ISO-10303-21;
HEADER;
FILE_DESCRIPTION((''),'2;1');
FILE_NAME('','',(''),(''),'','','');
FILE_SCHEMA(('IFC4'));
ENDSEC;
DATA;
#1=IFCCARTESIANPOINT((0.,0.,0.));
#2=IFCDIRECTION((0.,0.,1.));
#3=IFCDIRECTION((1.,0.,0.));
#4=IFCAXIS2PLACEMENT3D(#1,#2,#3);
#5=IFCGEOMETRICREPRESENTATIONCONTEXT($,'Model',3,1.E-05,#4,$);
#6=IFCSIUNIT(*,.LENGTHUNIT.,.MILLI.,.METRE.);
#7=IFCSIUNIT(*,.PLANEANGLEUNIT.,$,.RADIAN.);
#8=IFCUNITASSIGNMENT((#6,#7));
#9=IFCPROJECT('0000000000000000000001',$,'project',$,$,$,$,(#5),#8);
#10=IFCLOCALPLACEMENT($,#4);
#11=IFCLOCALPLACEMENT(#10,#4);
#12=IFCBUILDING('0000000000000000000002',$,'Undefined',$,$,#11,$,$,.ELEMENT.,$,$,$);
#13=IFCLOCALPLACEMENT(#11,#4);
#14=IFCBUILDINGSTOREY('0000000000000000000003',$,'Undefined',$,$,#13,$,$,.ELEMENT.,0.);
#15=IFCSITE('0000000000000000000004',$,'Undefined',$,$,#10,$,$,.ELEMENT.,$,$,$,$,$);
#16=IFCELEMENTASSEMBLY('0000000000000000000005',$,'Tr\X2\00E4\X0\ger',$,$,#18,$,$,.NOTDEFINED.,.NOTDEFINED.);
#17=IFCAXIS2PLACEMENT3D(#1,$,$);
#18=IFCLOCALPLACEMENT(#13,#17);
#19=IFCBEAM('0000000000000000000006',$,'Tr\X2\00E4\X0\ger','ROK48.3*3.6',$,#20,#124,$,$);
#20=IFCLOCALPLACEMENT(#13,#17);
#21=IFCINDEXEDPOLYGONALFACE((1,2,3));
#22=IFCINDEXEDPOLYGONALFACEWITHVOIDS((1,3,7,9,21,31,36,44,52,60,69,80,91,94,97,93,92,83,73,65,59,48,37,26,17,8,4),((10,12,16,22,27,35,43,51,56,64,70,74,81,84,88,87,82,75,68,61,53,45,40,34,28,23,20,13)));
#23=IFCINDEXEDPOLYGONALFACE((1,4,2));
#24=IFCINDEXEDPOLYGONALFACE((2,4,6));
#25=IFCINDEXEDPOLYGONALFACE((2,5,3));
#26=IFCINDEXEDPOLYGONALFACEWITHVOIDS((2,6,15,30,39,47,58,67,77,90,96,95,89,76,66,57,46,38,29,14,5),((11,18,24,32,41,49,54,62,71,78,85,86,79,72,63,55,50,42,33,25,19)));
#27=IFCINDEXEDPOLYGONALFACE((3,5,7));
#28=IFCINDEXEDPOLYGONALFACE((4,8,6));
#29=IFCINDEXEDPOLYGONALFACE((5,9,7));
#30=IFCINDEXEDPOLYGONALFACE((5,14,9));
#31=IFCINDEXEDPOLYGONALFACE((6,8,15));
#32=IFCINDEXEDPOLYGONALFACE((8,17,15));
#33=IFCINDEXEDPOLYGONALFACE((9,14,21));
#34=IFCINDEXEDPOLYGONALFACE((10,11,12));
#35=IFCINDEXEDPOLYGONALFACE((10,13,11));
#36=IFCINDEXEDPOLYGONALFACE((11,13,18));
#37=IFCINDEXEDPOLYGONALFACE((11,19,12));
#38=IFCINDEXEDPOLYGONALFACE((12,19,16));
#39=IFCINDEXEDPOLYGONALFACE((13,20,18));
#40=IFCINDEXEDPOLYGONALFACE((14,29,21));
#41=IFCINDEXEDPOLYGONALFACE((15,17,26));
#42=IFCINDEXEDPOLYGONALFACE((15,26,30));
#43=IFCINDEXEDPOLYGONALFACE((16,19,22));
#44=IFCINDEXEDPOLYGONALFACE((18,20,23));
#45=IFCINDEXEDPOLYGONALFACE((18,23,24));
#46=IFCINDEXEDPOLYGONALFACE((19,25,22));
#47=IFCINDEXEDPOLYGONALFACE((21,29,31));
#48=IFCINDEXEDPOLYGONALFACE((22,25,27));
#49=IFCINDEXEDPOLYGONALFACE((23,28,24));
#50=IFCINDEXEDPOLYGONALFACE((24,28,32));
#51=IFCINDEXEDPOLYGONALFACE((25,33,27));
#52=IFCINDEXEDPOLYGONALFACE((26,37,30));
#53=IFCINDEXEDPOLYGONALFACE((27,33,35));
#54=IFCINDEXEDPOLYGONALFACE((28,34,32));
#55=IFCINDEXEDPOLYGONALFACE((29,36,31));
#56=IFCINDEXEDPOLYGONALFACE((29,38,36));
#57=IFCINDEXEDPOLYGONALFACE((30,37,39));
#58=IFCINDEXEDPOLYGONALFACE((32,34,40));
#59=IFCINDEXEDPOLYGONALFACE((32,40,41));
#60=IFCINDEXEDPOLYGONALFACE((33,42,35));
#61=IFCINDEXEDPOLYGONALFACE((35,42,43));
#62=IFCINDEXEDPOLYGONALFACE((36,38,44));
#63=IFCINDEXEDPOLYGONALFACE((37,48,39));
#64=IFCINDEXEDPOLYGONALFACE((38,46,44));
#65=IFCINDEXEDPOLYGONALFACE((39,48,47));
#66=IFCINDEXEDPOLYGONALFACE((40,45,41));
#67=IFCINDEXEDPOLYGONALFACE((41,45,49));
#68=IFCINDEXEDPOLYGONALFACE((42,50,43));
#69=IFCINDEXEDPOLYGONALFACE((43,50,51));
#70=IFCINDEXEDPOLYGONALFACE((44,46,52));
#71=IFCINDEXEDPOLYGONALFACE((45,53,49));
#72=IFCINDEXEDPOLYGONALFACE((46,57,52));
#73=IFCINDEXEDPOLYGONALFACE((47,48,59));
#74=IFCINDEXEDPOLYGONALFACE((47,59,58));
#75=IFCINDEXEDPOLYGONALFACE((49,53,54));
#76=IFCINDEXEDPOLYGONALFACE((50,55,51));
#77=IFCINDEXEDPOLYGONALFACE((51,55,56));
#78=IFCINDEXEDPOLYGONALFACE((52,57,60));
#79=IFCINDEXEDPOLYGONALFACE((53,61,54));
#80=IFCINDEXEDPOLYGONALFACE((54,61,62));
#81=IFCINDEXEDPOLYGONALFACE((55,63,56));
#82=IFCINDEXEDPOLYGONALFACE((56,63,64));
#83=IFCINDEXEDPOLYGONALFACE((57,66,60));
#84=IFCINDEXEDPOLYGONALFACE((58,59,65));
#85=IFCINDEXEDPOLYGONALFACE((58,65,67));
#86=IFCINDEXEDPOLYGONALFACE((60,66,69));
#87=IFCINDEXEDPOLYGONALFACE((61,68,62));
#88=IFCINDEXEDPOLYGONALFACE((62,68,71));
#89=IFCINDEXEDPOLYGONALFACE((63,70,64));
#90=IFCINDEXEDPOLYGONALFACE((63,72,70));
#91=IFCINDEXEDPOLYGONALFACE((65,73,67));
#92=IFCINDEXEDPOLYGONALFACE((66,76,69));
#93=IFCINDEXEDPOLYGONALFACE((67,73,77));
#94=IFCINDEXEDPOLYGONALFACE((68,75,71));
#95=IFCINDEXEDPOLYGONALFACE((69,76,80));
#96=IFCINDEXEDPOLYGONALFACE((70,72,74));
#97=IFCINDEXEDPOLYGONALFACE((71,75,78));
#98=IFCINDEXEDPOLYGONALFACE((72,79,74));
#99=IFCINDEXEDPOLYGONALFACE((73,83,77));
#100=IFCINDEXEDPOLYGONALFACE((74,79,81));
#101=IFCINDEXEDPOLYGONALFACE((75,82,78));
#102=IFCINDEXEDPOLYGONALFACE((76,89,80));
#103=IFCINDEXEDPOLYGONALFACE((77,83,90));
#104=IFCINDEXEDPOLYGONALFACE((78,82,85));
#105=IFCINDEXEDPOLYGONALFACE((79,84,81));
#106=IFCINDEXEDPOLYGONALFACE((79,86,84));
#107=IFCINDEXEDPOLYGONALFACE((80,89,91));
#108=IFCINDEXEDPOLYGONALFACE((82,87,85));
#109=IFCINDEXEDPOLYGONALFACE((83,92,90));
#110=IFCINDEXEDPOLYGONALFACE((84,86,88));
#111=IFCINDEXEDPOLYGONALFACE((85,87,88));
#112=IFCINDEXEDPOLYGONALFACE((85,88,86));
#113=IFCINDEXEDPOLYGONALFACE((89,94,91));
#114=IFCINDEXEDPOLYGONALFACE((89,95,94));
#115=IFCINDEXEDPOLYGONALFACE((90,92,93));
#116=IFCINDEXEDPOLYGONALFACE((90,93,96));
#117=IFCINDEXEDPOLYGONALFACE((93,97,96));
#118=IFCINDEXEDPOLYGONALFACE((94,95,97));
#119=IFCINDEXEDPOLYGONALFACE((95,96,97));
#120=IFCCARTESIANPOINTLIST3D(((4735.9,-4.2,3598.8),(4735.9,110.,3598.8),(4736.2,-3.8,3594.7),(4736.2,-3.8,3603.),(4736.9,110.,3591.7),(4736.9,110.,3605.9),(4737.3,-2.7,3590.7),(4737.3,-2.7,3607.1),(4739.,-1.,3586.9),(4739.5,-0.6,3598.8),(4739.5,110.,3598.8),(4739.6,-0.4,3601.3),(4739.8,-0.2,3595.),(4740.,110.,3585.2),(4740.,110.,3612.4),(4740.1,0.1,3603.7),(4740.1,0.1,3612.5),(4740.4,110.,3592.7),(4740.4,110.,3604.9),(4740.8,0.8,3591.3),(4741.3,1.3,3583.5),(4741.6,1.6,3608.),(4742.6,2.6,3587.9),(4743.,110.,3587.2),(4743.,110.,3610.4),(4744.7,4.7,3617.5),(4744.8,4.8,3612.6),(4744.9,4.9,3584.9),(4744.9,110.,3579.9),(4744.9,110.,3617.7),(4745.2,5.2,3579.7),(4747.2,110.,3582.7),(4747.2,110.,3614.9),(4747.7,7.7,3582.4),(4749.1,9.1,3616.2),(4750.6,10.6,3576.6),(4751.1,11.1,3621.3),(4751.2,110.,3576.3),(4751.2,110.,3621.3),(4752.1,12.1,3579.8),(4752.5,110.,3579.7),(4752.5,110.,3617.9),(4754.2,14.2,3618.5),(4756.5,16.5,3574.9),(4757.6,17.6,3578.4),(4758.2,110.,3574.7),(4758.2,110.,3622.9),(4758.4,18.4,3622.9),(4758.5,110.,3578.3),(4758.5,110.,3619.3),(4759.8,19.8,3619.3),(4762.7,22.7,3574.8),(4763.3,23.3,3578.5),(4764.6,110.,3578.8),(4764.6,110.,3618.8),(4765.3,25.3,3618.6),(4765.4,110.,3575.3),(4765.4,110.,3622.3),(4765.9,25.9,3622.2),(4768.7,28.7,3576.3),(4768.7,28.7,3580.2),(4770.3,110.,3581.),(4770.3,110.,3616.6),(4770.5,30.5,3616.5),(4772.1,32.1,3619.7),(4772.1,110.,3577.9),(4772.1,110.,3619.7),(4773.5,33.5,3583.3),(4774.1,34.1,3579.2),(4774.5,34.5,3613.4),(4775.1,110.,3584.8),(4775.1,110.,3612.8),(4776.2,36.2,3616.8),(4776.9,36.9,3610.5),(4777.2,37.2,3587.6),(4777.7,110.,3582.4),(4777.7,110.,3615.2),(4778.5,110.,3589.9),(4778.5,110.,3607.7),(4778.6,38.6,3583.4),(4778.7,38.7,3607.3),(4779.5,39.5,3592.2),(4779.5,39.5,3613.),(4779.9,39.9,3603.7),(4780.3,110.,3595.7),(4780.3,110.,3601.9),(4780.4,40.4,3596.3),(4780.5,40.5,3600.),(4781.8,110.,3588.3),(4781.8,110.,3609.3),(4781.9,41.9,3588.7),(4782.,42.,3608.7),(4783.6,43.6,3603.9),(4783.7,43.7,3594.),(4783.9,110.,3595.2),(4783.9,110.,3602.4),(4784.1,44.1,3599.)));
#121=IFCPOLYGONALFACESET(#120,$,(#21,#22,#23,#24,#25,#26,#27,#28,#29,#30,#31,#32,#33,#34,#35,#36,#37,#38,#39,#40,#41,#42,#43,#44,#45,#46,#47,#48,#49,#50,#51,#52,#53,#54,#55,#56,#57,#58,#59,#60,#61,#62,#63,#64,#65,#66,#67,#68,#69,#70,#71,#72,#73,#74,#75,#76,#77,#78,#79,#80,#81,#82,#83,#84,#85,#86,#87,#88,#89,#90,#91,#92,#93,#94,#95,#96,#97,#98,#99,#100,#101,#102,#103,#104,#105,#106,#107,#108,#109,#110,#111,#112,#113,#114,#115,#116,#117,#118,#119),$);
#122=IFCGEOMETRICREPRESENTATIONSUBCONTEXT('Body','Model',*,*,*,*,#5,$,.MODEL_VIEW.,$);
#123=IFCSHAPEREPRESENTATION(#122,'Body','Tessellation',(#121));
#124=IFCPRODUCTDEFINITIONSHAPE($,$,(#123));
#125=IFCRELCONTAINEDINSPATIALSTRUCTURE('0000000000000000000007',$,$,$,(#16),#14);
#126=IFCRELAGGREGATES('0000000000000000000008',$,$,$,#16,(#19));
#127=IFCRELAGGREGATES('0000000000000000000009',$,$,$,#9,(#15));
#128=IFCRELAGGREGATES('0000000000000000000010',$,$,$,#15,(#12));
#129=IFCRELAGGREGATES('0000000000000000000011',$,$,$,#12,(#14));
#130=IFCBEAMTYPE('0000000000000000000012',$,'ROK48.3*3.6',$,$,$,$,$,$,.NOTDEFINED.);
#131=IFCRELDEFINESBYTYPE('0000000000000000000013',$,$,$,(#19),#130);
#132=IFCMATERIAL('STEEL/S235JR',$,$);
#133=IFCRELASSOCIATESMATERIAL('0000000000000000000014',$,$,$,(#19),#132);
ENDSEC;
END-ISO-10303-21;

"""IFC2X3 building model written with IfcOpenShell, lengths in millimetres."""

from ifc_helpers import new_model, si_unit, frame, origin_with_axes, origin_2d_with_axis, place, context, subcontext, project, spatial, hollow_circle, extrude, clip, halfspace, material, type_object, element, aggregate, save


model = new_model("IFC2X3")

# Units and contexts
model_context = context("Model", 3, precision=1e-05, world=origin_with_axes())
body_context = subcontext(model_context, "Body", "Model", "MODEL_VIEW")
ifc_project = project(units=[si_unit("LENGTHUNIT", "METRE", prefix="MILLI"), si_unit("PLANEANGLEUNIT", "RADIAN")], contexts=[model_context])

# Site, building, storey
site_placement = place(None, origin_with_axes())
site = spatial("IfcSite", under=ifc_project, at=site_placement, Name="Undefined", CompositionType="ELEMENT")
building_placement = place(site_placement, origin_with_axes())
building = spatial("IfcBuilding", under=site, at=building_placement, Name="Undefined", CompositionType="ELEMENT")
storey_placement = place(building_placement, origin_with_axes())
storey = spatial("IfcBuildingStorey", under=building, at=storey_placement, Name="Undefined", CompositionType="ELEMENT", Elevation=0.0)

# Shared definitions
ifc_material = material(Name="STEEL/S235JR")
beam_type = type_object("IfcBeamType", Name="ROK48.3*3.6", PredefinedType="NOTDEFINED")

# Element assembly, beam
assembly_1_placement = place(storey_placement, origin_with_axes())
assembly_1 = element("IfcElementAssembly", 1, at=assembly_1_placement, inside=storey, Name="Träger", AssemblyPlace="NOTDEFINED", PredefinedType="NOTDEFINED")
beam_1_placement = place(assembly_1_placement, frame((4760.0, 56.1, 3598.8), z_axis=(0.0, 0.0, -1.0), x_axis=(0.0, 1.0, 0.0)))
beam_1 = element("IfcBeam", 2, at=beam_1_placement, type_object=beam_type, material=ifc_material, Name="Träger", Description="ROK48.3*3.6", context=body_context, shape_type="Clipping", body=[
    clip(extrude(hollow_circle(Radius=24.1, WallThickness=3.6, at=origin_2d_with_axis()), frame((53.9, 0.0, 0.0), z_axis=(-1.0, 0.0, 0.0), x_axis=(0.0, -1.0, 0.0)), (0.0, 0.0, 1.0), 114.4), halfspace(frame((-60.3, -24.2, 0.0), z_axis=(-0.707107, 0.707107, 0.0), x_axis=(0.0, 0.0, -1.0)), False)),
])

aggregate(assembly_1, [beam_1])

save(model, "model.ifc")
